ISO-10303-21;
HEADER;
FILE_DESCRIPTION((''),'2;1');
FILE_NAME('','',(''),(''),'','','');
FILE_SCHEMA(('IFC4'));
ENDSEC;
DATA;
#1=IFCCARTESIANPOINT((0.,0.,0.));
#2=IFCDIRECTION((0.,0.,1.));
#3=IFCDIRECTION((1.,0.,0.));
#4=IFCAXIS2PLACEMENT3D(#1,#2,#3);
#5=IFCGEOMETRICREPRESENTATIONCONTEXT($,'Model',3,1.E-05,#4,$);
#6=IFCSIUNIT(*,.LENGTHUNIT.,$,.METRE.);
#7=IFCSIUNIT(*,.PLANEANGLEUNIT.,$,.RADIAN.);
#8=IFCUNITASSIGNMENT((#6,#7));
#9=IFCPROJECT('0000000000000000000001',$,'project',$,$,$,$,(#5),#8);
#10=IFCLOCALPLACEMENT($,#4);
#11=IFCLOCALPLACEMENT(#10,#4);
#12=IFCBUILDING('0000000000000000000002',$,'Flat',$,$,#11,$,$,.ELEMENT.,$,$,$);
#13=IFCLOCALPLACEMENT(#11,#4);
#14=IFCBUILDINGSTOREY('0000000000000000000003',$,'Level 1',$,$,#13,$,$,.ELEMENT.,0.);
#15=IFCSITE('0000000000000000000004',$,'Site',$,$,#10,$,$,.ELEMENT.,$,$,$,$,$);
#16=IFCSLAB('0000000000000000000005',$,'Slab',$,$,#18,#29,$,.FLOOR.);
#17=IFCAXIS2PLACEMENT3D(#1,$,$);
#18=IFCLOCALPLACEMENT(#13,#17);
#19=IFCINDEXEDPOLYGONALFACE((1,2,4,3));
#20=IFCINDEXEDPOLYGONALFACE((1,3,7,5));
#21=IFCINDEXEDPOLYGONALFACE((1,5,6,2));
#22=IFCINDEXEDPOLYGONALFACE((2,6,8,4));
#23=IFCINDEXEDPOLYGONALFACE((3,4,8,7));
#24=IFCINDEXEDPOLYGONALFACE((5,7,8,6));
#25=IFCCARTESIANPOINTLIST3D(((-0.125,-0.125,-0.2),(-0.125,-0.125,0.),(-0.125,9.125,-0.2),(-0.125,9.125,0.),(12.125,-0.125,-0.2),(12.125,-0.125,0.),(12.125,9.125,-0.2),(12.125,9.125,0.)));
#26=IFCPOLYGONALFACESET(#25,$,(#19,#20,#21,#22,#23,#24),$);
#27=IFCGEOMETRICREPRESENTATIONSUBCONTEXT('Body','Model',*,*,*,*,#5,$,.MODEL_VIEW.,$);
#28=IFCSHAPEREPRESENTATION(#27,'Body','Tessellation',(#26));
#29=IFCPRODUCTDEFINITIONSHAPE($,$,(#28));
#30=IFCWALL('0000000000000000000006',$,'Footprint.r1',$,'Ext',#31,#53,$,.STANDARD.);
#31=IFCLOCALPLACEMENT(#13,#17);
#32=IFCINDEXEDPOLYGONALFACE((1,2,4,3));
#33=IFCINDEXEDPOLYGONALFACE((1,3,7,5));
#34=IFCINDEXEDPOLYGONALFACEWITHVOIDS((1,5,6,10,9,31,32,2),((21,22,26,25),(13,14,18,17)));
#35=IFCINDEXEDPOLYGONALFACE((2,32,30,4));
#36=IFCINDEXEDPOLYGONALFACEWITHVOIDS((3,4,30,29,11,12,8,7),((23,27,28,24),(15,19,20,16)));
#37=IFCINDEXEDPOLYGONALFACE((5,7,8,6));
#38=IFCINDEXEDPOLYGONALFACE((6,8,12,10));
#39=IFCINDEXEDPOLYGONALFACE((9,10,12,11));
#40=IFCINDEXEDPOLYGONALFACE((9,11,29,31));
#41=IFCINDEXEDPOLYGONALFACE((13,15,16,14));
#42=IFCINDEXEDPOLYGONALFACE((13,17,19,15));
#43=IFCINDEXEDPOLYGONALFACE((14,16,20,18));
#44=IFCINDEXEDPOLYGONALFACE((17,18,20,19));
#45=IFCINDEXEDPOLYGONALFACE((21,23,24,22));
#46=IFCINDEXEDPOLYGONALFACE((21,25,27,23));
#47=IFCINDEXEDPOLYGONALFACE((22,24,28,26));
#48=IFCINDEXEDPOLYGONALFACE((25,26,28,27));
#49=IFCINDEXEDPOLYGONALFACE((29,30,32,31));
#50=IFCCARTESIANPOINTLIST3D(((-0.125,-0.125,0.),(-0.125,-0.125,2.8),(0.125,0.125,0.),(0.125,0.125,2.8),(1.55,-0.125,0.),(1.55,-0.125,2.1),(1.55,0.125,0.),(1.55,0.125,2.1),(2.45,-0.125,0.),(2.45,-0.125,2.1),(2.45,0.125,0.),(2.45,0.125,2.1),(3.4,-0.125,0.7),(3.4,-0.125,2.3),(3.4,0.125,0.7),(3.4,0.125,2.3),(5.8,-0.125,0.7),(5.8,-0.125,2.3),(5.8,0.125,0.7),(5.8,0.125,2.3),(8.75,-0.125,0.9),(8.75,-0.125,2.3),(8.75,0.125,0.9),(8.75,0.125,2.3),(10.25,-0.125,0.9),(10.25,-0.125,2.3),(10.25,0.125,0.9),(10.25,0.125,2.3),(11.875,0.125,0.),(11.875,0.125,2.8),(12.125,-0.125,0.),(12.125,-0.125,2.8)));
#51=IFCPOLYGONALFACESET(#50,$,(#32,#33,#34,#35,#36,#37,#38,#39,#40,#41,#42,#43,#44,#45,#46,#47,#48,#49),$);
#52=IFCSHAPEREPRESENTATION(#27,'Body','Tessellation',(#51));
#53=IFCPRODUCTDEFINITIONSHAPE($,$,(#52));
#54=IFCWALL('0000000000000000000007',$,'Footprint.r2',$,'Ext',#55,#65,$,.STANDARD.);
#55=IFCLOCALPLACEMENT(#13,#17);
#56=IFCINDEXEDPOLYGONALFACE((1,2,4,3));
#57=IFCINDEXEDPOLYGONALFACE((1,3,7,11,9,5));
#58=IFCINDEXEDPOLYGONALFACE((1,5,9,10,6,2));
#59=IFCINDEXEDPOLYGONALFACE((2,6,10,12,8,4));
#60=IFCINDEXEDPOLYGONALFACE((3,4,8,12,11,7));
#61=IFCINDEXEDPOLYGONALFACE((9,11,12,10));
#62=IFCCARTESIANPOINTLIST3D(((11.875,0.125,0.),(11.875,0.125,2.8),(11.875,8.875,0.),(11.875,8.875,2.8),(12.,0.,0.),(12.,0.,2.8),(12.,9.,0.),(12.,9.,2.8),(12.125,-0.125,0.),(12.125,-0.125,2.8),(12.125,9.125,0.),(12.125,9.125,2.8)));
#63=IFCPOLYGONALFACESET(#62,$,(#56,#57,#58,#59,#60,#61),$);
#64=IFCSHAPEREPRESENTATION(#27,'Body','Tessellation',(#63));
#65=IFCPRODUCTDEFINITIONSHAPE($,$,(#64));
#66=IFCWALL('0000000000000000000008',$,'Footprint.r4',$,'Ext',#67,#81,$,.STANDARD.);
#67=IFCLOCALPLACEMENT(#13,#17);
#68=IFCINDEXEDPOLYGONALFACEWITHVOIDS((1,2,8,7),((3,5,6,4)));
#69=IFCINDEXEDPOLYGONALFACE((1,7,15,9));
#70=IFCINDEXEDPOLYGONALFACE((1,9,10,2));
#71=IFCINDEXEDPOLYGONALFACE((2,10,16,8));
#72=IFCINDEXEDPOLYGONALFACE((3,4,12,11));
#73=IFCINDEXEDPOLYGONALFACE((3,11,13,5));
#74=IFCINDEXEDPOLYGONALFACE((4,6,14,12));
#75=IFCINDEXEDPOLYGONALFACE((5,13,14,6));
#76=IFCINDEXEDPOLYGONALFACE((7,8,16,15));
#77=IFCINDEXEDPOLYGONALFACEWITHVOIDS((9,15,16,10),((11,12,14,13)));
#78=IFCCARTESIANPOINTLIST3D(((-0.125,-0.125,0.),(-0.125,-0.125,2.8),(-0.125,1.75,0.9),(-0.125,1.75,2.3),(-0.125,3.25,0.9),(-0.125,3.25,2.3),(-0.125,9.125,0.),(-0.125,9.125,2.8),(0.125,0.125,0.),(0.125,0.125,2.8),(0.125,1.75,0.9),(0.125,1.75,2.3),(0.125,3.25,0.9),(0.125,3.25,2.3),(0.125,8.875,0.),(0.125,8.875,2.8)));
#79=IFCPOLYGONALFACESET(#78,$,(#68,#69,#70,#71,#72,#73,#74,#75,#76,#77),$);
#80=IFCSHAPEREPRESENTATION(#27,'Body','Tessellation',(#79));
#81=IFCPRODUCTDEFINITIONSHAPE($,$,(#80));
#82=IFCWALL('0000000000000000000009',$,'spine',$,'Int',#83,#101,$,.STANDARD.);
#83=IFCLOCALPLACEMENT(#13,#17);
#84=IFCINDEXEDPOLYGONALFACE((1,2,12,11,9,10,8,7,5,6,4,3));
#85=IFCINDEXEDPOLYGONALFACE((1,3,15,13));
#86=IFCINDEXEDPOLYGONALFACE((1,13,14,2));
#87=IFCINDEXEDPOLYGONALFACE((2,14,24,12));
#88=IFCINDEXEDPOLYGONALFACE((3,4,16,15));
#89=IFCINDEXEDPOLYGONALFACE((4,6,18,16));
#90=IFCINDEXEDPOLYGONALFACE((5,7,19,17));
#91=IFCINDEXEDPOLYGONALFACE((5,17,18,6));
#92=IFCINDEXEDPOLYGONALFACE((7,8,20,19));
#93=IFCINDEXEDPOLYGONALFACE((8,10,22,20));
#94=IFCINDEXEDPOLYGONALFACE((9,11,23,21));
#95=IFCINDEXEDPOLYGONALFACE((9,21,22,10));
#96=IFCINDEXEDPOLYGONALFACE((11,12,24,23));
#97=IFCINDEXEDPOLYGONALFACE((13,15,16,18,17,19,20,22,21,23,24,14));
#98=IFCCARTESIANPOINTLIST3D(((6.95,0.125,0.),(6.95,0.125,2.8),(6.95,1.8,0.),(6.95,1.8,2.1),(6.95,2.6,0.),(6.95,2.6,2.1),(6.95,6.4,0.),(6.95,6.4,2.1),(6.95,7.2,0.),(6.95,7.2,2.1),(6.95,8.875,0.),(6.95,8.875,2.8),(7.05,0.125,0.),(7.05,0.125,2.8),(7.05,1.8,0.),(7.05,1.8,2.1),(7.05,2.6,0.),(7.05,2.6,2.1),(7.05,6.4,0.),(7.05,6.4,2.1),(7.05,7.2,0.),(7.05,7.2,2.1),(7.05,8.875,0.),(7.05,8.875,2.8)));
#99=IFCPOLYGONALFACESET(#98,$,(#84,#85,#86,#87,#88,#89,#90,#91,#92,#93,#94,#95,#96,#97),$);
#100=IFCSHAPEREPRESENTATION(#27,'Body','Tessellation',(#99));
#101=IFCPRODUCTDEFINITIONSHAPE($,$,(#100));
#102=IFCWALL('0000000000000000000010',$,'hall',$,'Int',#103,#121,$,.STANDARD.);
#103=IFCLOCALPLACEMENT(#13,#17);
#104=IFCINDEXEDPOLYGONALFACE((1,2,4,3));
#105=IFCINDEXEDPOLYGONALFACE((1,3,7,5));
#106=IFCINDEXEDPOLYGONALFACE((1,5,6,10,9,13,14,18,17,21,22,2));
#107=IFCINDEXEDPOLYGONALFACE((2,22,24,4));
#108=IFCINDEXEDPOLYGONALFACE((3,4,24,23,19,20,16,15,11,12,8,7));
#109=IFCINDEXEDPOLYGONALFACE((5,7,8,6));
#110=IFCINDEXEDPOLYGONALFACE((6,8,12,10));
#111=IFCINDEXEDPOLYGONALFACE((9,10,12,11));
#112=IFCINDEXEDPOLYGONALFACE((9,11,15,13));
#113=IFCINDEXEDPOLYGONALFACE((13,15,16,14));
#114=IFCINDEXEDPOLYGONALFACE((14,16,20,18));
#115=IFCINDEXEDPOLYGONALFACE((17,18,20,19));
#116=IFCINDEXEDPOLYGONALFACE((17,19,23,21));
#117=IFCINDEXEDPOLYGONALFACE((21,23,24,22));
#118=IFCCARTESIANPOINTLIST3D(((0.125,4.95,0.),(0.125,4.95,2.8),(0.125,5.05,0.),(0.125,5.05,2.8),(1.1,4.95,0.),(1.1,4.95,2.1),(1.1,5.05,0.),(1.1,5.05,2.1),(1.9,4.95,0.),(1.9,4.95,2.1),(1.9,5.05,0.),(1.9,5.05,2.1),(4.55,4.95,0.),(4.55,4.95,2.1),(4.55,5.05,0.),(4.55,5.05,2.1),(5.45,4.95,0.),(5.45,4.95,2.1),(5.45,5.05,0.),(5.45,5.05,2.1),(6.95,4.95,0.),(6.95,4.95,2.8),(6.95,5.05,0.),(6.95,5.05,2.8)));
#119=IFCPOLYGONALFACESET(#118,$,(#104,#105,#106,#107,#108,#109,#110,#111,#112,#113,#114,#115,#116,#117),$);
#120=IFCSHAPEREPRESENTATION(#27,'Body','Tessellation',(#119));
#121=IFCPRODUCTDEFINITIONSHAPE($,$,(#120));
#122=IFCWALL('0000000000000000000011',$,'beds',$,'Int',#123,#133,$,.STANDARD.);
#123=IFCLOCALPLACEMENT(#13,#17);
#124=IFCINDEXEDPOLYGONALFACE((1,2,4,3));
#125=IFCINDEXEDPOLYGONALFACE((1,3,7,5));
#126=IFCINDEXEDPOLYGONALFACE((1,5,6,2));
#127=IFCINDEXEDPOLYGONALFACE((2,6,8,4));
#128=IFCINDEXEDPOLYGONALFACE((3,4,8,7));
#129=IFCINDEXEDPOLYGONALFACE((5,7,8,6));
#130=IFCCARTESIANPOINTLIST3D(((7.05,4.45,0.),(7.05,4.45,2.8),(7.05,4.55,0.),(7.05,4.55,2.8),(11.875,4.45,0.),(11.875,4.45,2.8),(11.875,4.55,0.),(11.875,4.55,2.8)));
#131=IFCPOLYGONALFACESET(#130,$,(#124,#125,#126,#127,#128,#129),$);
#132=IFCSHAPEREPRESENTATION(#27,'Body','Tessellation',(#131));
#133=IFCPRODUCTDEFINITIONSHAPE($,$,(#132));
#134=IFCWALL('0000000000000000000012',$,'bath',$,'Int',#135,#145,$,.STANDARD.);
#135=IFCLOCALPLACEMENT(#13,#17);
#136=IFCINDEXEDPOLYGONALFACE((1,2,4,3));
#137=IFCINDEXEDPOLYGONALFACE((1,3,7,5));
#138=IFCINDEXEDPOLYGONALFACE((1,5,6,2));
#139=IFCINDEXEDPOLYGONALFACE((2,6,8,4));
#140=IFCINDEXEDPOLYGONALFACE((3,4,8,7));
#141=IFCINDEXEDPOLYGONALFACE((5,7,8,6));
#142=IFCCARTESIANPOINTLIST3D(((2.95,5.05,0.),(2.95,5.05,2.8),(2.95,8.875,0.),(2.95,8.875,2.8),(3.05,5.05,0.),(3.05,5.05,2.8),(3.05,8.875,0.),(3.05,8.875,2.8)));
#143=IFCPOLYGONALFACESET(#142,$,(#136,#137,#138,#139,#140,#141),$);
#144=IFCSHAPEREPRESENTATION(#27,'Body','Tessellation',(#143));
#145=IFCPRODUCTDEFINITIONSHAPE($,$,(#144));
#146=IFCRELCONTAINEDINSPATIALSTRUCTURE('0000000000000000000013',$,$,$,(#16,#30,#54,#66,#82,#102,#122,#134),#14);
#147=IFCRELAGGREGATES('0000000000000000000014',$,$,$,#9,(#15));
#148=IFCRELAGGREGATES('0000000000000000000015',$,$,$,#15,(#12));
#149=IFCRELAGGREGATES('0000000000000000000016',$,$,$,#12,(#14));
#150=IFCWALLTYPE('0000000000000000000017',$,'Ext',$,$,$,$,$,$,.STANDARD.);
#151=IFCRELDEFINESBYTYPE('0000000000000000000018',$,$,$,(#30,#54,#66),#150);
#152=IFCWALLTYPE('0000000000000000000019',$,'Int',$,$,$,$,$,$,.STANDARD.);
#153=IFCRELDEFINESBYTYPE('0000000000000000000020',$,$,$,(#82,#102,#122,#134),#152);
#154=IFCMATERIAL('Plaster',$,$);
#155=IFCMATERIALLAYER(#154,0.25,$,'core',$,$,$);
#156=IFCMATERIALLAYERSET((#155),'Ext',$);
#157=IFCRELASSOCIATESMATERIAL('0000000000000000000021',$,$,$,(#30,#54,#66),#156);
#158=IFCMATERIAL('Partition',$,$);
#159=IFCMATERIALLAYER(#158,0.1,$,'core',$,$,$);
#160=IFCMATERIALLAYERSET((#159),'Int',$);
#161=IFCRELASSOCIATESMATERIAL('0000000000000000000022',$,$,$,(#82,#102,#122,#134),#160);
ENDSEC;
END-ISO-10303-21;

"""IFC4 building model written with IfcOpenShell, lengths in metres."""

from ifc_helpers import new_model, si_unit, frame, origin_with_axes, origin_2d_with_axis, place, context, subcontext, project, spatial, polyline, rectangle, outline, extrude, material, layer, layer_set, layer_usage, type_object, element, save


model = new_model("IFC4")

# Units and contexts
model_context = context("Model", 3, precision=1e-05, world=origin_with_axes())
body_context = subcontext(model_context, "Body", "Model", "MODEL_VIEW")
ifc_project = project(units=[si_unit("LENGTHUNIT", "METRE"), si_unit("PLANEANGLEUNIT", "RADIAN")], contexts=[model_context])

# Site, building, storey
site_placement = place(None, origin_with_axes())
site = spatial("IfcSite", under=ifc_project, at=site_placement, Name="Site", CompositionType="ELEMENT")
building_placement = place(site_placement, origin_with_axes())
building = spatial("IfcBuilding", under=site, at=building_placement, Name="Flat", CompositionType="ELEMENT")
storey_placement = place(building_placement, origin_with_axes())
storey = spatial("IfcBuildingStorey", under=building, at=storey_placement, Name="Level 1", CompositionType="ELEMENT", Elevation=0.0)

# Slab
slab_placement = place(storey_placement, frame((0.0, 0.0, -0.2), z_axis=(0.0, 0.0, 1.0), x_axis=(1.0, 0.0, 0.0)))
element("IfcSlab", 1, at=slab_placement, inside=storey, Name="Slab", PredefinedType="FLOOR", context=body_context, shape_type="SweptSolid", body=[
    extrude(outline(polyline([(12.125, -0.125), (12.125, 9.125), (-0.125, 9.125), (-0.125, -0.125), (12.125, -0.125)])), origin_with_axes(), (0.0, 0.0, 1.0), 0.2),
])

# Wall, openings
ifc_material_1 = material(Name="Plaster")
ifc_layer_1 = layer(ifc_material_1, 0.25, Name="core")
ifc_layer_set_1 = layer_set([ifc_layer_1], Name="Ext")
ifc_layer_usage_1 = layer_usage(ifc_layer_set_1, "AXIS2", "POSITIVE", -0.125)
wall_type_1 = type_object("IfcWallType", Name="Ext", PredefinedType="STANDARD")
wall_1_placement = place(storey_placement, origin_with_axes())
wall_1 = element("IfcWall", 2, at=wall_1_placement, inside=storey, type_object=wall_type_1, material=ifc_layer_usage_1, Name="Footprint.r1", ObjectType="Ext", PredefinedType="STANDARD", context=body_context, shape_type="SweptSolid", body=[
    extrude(outline(polyline([(-0.125, -0.125), (12.125, -0.125), (12.0, 0.0), (11.875, 0.125), (0.125, 0.125), (0.0, 0.0), (-0.125, -0.125)])), origin_with_axes(), (0.0, 0.0, 1.0), 2.8),
])
opening_1_placement = place(wall_1_placement, frame((2.0, -0.135, 1.05), z_axis=(0.0, 1.0, 0.0), x_axis=(1.0, 0.0, 0.0)))
element("IfcOpeningElement", 3, at=opening_1_placement, cuts=wall_1, PredefinedType="OPENING", context=body_context, shape_type="SweptSolid", body=[
    extrude(rectangle(XDim=0.9, YDim=2.1, at=origin_2d_with_axis()), origin_with_axes(), (0.0, 0.0, 1.0), 0.27),
])
opening_2_placement = place(wall_1_placement, frame((4.6, -0.135, 1.5), z_axis=(0.0, 1.0, 0.0), x_axis=(1.0, 0.0, 0.0)))
element("IfcOpeningElement", 4, at=opening_2_placement, cuts=wall_1, PredefinedType="OPENING", context=body_context, shape_type="SweptSolid", body=[
    extrude(rectangle(XDim=2.4, YDim=1.6, at=origin_2d_with_axis()), origin_with_axes(), (0.0, 0.0, 1.0), 0.27),
])
opening_3_placement = place(wall_1_placement, frame((9.5, -0.135, 1.6), z_axis=(0.0, 1.0, 0.0), x_axis=(1.0, 0.0, 0.0)))
element("IfcOpeningElement", 5, at=opening_3_placement, cuts=wall_1, PredefinedType="OPENING", context=body_context, shape_type="SweptSolid", body=[
    extrude(rectangle(XDim=1.5, YDim=1.4, at=origin_2d_with_axis()), origin_with_axes(), (0.0, 0.0, 1.0), 0.27),
])

# Wall
ifc_layer_usage_2 = layer_usage(ifc_layer_set_1, "AXIS2", "POSITIVE", -0.125)
wall_2_placement = place(storey_placement, frame((12.0, 0.0, 0.0), z_axis=(0.0, 0.0, 1.0), x_axis=(0.0, 1.0, 0.0)))
element("IfcWall", 6, at=wall_2_placement, inside=storey, type_object=wall_type_1, material=ifc_layer_usage_2, Name="Footprint.r2", ObjectType="Ext", PredefinedType="STANDARD", context=body_context, shape_type="SweptSolid", body=[
    extrude(outline(polyline([(-0.125, -0.125), (9.125, -0.125), (9.0, 0.0), (8.875, 0.125), (0.125, 0.125), (0.0, 0.0), (-0.125, -0.125)])), origin_with_axes(), (0.0, 0.0, 1.0), 2.8),
])

# Wall, opening
ifc_layer_usage_3 = layer_usage(ifc_layer_set_1, "AXIS2", "POSITIVE", -0.125)
wall_3_placement = place(storey_placement, frame((0.0, 9.0, 0.0), z_axis=(0.0, 0.0, 1.0), x_axis=(0.0, -1.0, 0.0)))
wall_3 = element("IfcWall", 7, at=wall_3_placement, inside=storey, type_object=wall_type_1, material=ifc_layer_usage_3, Name="Footprint.r4", ObjectType="Ext", PredefinedType="STANDARD", context=body_context, shape_type="SweptSolid", body=[
    extrude(outline(polyline([(-0.125, -0.125), (9.125, -0.125), (9.0, 0.0), (8.875, 0.125), (0.125, 0.125), (0.0, 0.0), (-0.125, -0.125)])), origin_with_axes(), (0.0, 0.0, 1.0), 2.8),
])
opening_4_placement = place(wall_3_placement, frame((6.5, -0.135, 1.6), z_axis=(0.0, 1.0, 0.0), x_axis=(1.0, 0.0, 0.0)))
element("IfcOpeningElement", 8, at=opening_4_placement, cuts=wall_3, PredefinedType="OPENING", context=body_context, shape_type="SweptSolid", body=[
    extrude(rectangle(XDim=1.5, YDim=1.4, at=origin_2d_with_axis()), origin_with_axes(), (0.0, 0.0, 1.0), 0.27),
])

# Walls, openings
ifc_material_2 = material(Name="Partition")
ifc_layer_2 = layer(ifc_material_2, 0.1, Name="core")
ifc_layer_set_2 = layer_set([ifc_layer_2], Name="Int")
ifc_layer_usage_4 = layer_usage(ifc_layer_set_2, "AXIS2", "POSITIVE", -0.05)
wall_type_2 = type_object("IfcWallType", Name="Int", PredefinedType="STANDARD")
wall_4_placement = place(storey_placement, frame((7.0, 0.0, 0.0), z_axis=(0.0, 0.0, 1.0), x_axis=(0.0, 1.0, 0.0)))
wall_4 = element("IfcWall", 9, at=wall_4_placement, inside=storey, type_object=wall_type_2, material=ifc_layer_usage_4, Name="spine", ObjectType="Int", PredefinedType="STANDARD", context=body_context, shape_type="SweptSolid", body=[
    extrude(outline(polyline([(0.125, -0.05), (8.875, -0.05), (8.875, 0.05), (0.125, 0.05), (0.125, -0.05)])), origin_with_axes(), (0.0, 0.0, 1.0), 2.8),
])
opening_5_placement = place(wall_4_placement, frame((2.2, -0.06, 1.05), z_axis=(0.0, 1.0, 0.0), x_axis=(1.0, 0.0, 0.0)))
element("IfcOpeningElement", 10, at=opening_5_placement, cuts=wall_4, PredefinedType="OPENING", context=body_context, shape_type="SweptSolid", body=[
    extrude(rectangle(XDim=0.8, YDim=2.1, at=origin_2d_with_axis()), origin_with_axes(), (0.0, 0.0, 1.0), 0.12),
])
opening_6_placement = place(wall_4_placement, frame((6.8, -0.06, 1.05), z_axis=(0.0, 1.0, 0.0), x_axis=(1.0, 0.0, 0.0)))
element("IfcOpeningElement", 11, at=opening_6_placement, cuts=wall_4, PredefinedType="OPENING", context=body_context, shape_type="SweptSolid", body=[
    extrude(rectangle(XDim=0.8, YDim=2.1, at=origin_2d_with_axis()), origin_with_axes(), (0.0, 0.0, 1.0), 0.12),
])
ifc_layer_usage_5 = layer_usage(ifc_layer_set_2, "AXIS2", "POSITIVE", -0.05)
wall_5_placement = place(storey_placement, frame((0.0, 5.0, 0.0), z_axis=(0.0, 0.0, 1.0), x_axis=(1.0, 0.0, 0.0)))
wall_5 = element("IfcWall", 12, at=wall_5_placement, inside=storey, type_object=wall_type_2, material=ifc_layer_usage_5, Name="hall", ObjectType="Int", PredefinedType="STANDARD", context=body_context, shape_type="SweptSolid", body=[
    extrude(outline(polyline([(0.125, -0.05), (6.95, -0.05), (6.95, 0.05), (0.125, 0.05), (0.125, -0.05)])), origin_with_axes(), (0.0, 0.0, 1.0), 2.8),
])
opening_7_placement = place(wall_5_placement, frame((1.5, -0.06, 1.05), z_axis=(0.0, 1.0, 0.0), x_axis=(1.0, 0.0, 0.0)))
element("IfcOpeningElement", 13, at=opening_7_placement, cuts=wall_5, PredefinedType="OPENING", context=body_context, shape_type="SweptSolid", body=[
    extrude(rectangle(XDim=0.8, YDim=2.1, at=origin_2d_with_axis()), origin_with_axes(), (0.0, 0.0, 1.0), 0.12),
])
opening_8_placement = place(wall_5_placement, frame((5.0, -0.06, 1.05), z_axis=(0.0, 1.0, 0.0), x_axis=(1.0, 0.0, 0.0)))
element("IfcOpeningElement", 14, at=opening_8_placement, cuts=wall_5, PredefinedType="OPENING", context=body_context, shape_type="SweptSolid", body=[
    extrude(rectangle(XDim=0.9, YDim=2.1, at=origin_2d_with_axis()), origin_with_axes(), (0.0, 0.0, 1.0), 0.12),
])

# Walls
ifc_layer_usage_6 = layer_usage(ifc_layer_set_2, "AXIS2", "POSITIVE", -0.05)
wall_6_placement = place(storey_placement, frame((7.0, 4.5, 0.0), z_axis=(0.0, 0.0, 1.0), x_axis=(1.0, 0.0, 0.0)))
element("IfcWall", 15, at=wall_6_placement, inside=storey, type_object=wall_type_2, material=ifc_layer_usage_6, Name="beds", ObjectType="Int", PredefinedType="STANDARD", context=body_context, shape_type="SweptSolid", body=[
    extrude(outline(polyline([(0.05, -0.05), (4.875, -0.05), (4.875, 0.05), (0.05, 0.05), (0.05, -0.05)])), origin_with_axes(), (0.0, 0.0, 1.0), 2.8),
])
ifc_layer_usage_7 = layer_usage(ifc_layer_set_2, "AXIS2", "POSITIVE", -0.05)
wall_7_placement = place(storey_placement, frame((3.0, 5.0, 0.0), z_axis=(0.0, 0.0, 1.0), x_axis=(0.0, 1.0, 0.0)))
element("IfcWall", 16, at=wall_7_placement, inside=storey, type_object=wall_type_2, material=ifc_layer_usage_7, Name="bath", ObjectType="Int", PredefinedType="STANDARD", context=body_context, shape_type="SweptSolid", body=[
    extrude(outline(polyline([(0.05, -0.05), (3.875, -0.05), (3.875, 0.05), (0.05, 0.05), (0.05, -0.05)])), origin_with_axes(), (0.0, 0.0, 1.0), 2.8),
])

save(model, "model.ifc")
